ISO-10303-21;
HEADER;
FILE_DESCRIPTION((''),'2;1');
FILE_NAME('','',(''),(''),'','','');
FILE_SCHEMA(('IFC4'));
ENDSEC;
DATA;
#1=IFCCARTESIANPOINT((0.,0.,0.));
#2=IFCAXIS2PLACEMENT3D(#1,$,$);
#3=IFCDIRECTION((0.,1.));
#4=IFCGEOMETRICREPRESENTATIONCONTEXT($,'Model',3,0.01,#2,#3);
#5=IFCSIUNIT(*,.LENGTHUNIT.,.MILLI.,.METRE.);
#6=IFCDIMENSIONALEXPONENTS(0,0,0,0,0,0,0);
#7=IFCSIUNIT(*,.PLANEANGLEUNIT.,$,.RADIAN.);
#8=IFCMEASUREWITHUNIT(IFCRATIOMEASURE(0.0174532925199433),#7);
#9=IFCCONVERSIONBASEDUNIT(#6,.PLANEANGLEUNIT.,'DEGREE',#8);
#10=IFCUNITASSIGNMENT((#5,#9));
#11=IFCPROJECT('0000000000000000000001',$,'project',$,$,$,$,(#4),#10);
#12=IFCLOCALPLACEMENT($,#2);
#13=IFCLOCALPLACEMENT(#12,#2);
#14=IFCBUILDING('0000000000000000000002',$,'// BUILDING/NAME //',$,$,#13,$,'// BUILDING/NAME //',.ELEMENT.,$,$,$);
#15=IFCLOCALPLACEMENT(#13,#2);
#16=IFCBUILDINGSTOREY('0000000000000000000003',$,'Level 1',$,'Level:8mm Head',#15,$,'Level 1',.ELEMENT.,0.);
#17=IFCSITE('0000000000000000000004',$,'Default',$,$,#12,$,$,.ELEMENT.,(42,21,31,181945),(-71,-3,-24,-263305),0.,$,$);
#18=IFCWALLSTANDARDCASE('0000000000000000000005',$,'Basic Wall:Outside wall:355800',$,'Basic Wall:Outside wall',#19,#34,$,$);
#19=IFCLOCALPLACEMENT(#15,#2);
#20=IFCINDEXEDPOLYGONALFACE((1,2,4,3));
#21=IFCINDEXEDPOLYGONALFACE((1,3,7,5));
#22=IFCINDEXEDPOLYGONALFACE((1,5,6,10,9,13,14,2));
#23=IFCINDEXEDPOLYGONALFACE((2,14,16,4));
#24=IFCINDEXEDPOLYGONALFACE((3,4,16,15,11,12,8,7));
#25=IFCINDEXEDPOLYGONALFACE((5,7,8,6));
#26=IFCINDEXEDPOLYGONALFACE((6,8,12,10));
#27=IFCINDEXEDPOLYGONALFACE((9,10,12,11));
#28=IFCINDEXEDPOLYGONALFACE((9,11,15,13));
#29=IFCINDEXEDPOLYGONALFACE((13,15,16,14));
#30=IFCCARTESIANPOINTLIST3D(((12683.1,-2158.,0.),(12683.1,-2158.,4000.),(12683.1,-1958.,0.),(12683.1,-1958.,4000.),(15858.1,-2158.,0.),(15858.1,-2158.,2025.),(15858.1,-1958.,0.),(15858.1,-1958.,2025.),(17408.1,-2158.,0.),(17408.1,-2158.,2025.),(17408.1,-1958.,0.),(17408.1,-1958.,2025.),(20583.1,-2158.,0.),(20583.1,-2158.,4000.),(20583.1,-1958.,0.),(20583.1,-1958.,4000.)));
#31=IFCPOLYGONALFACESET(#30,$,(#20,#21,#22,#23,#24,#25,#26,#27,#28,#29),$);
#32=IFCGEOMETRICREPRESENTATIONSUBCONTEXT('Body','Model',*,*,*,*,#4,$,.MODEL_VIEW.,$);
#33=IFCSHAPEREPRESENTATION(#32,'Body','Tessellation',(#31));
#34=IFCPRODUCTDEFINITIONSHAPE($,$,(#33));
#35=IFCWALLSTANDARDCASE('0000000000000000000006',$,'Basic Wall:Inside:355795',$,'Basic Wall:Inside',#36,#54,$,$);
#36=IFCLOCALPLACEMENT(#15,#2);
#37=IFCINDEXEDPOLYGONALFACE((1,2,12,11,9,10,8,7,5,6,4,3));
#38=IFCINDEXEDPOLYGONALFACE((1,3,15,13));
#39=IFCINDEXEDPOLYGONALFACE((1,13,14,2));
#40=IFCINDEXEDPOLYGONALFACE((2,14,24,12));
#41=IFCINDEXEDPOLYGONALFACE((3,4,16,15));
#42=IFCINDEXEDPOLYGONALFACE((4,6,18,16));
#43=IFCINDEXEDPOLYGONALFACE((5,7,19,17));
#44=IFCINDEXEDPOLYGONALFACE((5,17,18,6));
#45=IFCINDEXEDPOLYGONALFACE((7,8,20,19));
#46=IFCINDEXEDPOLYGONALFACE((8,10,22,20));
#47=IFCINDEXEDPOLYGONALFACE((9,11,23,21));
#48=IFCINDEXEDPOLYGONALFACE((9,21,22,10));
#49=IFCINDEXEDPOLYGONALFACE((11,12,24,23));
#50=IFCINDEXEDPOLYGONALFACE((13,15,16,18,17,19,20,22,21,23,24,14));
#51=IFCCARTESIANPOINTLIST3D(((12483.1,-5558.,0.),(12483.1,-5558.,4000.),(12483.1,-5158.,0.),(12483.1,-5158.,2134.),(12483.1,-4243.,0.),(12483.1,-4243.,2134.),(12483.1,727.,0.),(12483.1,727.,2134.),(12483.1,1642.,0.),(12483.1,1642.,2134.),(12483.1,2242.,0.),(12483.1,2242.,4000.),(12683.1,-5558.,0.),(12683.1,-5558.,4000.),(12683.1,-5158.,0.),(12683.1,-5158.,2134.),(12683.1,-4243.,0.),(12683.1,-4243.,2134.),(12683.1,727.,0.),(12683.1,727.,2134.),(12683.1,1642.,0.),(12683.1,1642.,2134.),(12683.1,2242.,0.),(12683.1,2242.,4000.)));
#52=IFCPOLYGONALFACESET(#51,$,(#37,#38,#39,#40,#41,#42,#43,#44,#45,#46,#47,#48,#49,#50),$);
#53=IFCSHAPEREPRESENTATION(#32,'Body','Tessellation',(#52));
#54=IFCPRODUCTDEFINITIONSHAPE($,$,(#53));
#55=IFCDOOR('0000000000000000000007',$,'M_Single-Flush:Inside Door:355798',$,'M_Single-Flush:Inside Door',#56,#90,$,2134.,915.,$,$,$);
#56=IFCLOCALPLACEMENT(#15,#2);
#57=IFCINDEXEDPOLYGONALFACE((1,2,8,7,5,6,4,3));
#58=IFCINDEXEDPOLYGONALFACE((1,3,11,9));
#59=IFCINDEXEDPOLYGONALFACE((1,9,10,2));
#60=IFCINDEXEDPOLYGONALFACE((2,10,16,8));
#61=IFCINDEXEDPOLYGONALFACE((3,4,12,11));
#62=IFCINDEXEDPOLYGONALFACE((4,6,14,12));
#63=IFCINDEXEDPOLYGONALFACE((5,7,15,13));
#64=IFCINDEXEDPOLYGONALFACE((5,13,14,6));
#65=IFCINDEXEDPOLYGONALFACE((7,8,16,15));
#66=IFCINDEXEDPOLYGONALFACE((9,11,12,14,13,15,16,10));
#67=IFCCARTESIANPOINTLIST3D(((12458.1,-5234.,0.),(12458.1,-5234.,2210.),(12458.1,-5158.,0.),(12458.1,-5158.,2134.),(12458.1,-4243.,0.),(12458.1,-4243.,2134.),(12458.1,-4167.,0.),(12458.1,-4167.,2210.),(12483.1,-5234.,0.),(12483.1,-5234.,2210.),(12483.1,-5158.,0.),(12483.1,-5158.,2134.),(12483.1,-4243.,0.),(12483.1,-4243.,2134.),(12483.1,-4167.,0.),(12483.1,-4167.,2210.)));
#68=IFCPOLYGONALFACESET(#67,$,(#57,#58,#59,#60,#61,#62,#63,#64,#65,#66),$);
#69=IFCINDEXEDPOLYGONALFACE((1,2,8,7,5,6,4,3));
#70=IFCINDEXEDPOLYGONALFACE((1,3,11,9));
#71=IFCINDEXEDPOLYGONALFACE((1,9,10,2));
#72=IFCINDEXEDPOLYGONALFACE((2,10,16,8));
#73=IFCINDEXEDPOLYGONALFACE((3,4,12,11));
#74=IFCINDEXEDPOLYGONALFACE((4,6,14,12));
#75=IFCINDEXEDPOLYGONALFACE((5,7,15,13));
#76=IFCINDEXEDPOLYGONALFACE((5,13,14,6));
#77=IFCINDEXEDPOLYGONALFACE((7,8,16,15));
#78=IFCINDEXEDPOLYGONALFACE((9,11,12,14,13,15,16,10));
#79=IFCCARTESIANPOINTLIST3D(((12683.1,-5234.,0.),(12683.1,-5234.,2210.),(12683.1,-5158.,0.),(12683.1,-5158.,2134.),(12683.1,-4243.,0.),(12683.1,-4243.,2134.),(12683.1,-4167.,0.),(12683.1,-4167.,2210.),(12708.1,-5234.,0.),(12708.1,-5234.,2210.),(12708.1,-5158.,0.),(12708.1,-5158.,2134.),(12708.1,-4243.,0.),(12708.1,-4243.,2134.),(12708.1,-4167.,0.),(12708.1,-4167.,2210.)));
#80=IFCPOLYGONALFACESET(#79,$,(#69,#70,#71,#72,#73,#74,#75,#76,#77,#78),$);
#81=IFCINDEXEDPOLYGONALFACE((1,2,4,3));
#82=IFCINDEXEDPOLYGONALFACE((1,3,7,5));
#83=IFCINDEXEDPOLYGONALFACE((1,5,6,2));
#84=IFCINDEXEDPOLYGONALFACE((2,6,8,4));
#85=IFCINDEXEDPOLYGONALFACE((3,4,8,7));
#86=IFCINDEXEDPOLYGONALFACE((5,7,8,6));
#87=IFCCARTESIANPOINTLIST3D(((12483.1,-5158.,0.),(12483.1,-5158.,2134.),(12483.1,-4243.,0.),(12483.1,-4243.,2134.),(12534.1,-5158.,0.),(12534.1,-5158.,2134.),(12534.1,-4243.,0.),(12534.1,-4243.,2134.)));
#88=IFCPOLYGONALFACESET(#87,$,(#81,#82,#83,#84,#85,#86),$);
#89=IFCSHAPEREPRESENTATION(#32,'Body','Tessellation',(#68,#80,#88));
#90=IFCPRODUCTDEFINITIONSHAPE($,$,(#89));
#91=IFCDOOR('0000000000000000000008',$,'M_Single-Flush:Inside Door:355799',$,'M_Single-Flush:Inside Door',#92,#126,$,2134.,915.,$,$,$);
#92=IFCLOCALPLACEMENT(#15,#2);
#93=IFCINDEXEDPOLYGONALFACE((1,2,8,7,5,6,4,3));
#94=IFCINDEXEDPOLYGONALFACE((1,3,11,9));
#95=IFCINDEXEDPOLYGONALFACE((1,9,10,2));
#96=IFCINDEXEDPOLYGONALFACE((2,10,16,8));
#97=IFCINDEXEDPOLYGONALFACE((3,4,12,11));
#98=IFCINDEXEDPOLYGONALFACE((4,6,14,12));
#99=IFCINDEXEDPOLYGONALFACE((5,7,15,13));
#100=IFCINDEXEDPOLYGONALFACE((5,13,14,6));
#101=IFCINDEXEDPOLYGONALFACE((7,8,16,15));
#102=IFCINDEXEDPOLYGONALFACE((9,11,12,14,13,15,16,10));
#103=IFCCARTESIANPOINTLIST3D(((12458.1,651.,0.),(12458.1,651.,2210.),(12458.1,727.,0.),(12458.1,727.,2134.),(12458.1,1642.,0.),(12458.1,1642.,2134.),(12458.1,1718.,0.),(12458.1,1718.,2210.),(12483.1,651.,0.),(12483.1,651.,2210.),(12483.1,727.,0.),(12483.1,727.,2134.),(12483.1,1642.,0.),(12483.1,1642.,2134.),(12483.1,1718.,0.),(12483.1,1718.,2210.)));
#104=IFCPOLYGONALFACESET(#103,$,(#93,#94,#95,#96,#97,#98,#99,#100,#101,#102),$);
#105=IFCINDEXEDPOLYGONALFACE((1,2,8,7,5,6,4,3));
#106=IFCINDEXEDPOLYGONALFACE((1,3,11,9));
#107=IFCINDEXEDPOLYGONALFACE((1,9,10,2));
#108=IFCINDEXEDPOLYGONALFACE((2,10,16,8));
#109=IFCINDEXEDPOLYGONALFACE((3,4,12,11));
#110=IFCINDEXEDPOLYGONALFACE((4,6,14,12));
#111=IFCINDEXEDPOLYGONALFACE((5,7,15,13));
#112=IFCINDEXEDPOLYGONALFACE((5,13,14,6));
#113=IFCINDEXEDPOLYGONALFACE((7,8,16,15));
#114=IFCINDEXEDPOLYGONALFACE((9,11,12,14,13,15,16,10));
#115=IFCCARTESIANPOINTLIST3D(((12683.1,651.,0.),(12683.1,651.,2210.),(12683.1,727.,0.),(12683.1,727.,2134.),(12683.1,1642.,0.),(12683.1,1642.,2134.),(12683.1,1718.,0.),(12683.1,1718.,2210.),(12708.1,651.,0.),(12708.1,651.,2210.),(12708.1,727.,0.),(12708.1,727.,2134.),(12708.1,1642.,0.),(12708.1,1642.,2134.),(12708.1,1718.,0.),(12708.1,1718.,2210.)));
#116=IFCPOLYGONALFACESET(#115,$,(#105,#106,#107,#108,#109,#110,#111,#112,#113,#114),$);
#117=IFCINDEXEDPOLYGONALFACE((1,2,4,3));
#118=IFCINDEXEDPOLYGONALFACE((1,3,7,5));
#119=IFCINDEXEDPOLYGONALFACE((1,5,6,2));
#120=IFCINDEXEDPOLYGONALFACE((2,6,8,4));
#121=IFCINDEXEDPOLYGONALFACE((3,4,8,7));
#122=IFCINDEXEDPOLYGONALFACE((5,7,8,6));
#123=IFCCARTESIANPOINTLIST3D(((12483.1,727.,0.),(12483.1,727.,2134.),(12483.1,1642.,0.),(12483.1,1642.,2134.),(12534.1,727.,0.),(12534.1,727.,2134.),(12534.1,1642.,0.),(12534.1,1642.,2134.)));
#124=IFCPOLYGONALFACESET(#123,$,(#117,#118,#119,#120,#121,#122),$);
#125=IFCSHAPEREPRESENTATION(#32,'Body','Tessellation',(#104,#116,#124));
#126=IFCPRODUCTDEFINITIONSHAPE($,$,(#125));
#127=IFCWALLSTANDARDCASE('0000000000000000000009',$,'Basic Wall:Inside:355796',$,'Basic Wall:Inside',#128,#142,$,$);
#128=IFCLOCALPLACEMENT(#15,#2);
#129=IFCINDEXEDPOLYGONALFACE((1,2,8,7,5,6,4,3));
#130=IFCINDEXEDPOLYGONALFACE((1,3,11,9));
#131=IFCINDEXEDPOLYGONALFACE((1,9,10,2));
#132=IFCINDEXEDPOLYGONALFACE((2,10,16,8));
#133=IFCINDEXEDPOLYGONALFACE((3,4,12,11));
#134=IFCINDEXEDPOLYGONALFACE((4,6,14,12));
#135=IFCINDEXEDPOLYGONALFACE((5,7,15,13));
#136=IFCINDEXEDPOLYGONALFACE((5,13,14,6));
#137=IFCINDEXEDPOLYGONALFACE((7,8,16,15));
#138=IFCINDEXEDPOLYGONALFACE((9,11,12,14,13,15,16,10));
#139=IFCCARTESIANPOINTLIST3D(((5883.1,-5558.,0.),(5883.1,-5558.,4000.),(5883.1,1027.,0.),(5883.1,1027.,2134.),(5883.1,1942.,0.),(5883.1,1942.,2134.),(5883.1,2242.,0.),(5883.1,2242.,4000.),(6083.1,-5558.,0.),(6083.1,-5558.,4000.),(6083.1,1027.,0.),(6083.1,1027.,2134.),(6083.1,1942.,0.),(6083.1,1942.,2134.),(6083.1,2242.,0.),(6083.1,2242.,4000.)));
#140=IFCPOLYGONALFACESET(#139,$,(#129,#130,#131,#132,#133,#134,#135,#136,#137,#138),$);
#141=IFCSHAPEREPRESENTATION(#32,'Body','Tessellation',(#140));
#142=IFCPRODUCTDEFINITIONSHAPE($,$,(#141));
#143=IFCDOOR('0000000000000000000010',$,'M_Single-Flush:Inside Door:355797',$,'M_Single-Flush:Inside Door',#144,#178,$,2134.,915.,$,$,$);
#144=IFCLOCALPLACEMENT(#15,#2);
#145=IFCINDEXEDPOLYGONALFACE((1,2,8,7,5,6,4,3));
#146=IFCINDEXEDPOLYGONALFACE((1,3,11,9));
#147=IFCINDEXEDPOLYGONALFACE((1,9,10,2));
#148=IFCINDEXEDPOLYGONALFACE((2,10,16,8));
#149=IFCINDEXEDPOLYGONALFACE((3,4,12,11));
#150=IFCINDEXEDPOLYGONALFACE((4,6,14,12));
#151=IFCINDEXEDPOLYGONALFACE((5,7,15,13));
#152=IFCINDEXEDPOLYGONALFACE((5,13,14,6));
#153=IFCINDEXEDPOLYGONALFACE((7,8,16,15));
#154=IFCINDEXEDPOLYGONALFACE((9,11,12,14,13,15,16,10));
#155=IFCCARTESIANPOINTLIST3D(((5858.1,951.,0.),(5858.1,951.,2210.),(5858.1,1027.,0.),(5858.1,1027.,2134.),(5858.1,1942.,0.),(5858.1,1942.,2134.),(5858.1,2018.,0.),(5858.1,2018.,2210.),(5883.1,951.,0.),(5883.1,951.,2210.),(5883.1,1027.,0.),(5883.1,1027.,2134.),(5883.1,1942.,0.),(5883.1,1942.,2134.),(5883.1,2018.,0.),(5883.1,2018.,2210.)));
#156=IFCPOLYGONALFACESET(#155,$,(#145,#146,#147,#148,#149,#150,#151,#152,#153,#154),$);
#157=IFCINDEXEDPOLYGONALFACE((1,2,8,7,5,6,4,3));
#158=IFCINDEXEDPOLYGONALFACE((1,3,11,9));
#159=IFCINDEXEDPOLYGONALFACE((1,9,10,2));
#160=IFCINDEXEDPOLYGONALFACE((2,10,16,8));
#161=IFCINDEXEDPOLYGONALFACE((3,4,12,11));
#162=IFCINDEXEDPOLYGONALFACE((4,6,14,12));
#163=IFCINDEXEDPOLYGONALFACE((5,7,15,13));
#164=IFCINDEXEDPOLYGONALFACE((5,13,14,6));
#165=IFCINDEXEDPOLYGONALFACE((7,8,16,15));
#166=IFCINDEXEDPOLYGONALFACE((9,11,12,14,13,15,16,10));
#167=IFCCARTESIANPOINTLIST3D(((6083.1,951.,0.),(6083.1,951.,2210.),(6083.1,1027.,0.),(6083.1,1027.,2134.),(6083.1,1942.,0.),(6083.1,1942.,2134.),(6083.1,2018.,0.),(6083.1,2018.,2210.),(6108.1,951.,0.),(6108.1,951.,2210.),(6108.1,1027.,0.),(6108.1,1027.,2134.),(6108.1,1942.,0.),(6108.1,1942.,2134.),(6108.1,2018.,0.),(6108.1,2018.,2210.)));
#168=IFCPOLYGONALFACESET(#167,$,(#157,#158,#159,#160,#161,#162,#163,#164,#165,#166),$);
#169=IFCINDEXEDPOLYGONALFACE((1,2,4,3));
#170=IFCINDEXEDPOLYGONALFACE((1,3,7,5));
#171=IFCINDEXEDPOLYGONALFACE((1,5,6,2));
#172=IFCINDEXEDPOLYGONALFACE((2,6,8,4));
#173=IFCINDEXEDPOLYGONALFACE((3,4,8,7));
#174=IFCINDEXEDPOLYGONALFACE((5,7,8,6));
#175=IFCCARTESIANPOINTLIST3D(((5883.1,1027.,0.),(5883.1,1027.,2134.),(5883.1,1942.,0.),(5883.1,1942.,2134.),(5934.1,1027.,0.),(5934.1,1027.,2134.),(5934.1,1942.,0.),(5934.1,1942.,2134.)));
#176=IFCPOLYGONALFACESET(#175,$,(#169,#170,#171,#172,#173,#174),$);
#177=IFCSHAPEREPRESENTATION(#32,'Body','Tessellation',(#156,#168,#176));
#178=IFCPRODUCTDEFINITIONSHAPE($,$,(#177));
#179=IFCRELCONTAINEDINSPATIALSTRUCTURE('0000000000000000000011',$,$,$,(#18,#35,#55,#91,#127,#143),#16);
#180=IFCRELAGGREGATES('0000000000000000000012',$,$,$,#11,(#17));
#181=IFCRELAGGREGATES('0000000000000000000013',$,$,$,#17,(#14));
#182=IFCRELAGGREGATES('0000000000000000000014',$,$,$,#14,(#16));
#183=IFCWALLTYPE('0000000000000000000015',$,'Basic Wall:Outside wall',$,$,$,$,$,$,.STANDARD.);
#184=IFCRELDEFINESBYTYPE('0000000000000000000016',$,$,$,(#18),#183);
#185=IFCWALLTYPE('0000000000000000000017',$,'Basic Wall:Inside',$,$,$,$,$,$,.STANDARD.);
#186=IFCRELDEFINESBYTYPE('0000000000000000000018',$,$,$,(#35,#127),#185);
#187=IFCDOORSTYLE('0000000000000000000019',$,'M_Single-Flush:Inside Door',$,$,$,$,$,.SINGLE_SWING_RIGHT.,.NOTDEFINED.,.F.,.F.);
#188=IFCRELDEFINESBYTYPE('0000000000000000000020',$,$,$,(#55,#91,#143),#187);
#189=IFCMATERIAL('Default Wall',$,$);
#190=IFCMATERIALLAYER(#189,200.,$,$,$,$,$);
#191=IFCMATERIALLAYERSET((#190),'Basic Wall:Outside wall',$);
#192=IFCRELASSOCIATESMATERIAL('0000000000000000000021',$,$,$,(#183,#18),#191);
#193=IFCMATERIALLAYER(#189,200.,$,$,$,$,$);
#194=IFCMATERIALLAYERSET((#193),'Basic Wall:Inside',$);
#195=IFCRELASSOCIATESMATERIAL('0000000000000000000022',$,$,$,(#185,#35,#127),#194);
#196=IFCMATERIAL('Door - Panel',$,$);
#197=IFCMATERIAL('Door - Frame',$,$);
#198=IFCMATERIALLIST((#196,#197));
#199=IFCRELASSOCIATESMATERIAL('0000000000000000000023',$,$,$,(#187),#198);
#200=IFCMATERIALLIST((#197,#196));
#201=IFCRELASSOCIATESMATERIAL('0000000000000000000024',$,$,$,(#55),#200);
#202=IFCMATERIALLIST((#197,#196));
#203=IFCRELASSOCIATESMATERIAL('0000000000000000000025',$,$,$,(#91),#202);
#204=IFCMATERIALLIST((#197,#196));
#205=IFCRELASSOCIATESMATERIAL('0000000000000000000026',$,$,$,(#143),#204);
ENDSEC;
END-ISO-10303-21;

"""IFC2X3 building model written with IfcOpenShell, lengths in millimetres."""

from ifc_helpers import new_model, entity, si_unit, converted_unit, direction, frame, frame_2d, origin, place, context, subcontext, project, spatial, polyline, rectangle, outline, extrude, source, transform, mapped, material, material_list, layer, layer_set, layer_usage, type_object, type_shapes, element, fill, save


model = new_model("IFC2X3")

# Units and contexts
model_context = context("Model", 3, precision=0.01, world=origin(), true_north=direction((0.0, 1.0)))
body_context = subcontext(model_context, "Body", "Model", "MODEL_VIEW")
ifc_project = project(units=[si_unit("LENGTHUNIT", "METRE", prefix="MILLI"), converted_unit("PLANEANGLEUNIT", "DEGREE", entity("IfcRatioMeasure", 0.0174532925199433), si_unit("PLANEANGLEUNIT", "RADIAN"), dimensions=[0, 0, 0, 0, 0, 0, 0])], contexts=[model_context])

# Site, building, storey
site_placement = place(None, origin())
site = spatial("IfcSite", under=ifc_project, at=site_placement, Name="Default", CompositionType="ELEMENT", RefLatitude=(42, 21, 31, 181945), RefLongitude=(-71, -3, -24, -263305), RefElevation=0.0)
building_placement = place(site_placement, origin())
building = spatial("IfcBuilding", under=site, at=building_placement, Name="// BUILDING/NAME //", LongName="// BUILDING/NAME //", CompositionType="ELEMENT")
storey_placement = place(building_placement, origin())
storey = spatial("IfcBuildingStorey", under=building, at=storey_placement, Name="Level 1", ObjectType="Level:8mm Head", LongName="Level 1", CompositionType="ELEMENT", Elevation=0.0)

# Wall, opening
ifc_material_1 = material(Name="Default Wall")
ifc_layer_1 = layer(ifc_material_1, 200.0)
ifc_layer_set_1 = layer_set([ifc_layer_1], Name="Basic Wall:Outside wall")
ifc_layer_usage_1 = layer_usage(ifc_layer_set_1, "AXIS2", "NEGATIVE", 100.0)
wall_type_1 = type_object("IfcWallType", Name="Basic Wall:Outside wall", PredefinedType="STANDARD", material=ifc_layer_set_1)
wall_1_placement = place(storey_placement, frame((12683.1, -2058.0, 0.0)))
wall_1 = element("IfcWallStandardCase", 1, at=wall_1_placement, inside=storey, type_object=wall_type_1, material=ifc_layer_usage_1, Name="Basic Wall:Outside wall:355800", ObjectType="Basic Wall:Outside wall", context=body_context, shape_type="SweptSolid", body=[
    extrude(rectangle(XDim=7900.0, YDim=200.0, at=frame_2d((3950.0, 0.0), x_axis=(-1.0, 0.0))), origin(), (0.0, 0.0, 1.0), 4000.0),
])
opening_1_placement = place(wall_1_placement, frame((4725.0, 100.0, 0.0)))
element("IfcOpeningElement", 2, at=opening_1_placement, cuts=wall_1, ObjectType="Opening", context=body_context, shape_type="SweptSolid", body=[
    extrude(rectangle(XDim=2025.0, YDim=1550.0, at=frame_2d((1012.5, 775.0), x_axis=(1.0, 0.0))), frame((0.0, 0.0, 0.0), z_axis=(0.0, -1.0, 0.0), x_axis=(0.0, 0.0, 1.0)), (0.0, 0.0, 1.0), 200.0),
])

# Wall, openings, doors
ifc_layer_2 = layer(ifc_material_1, 200.0)
ifc_layer_set_2 = layer_set([ifc_layer_2], Name="Basic Wall:Inside")
ifc_layer_usage_2 = layer_usage(ifc_layer_set_2, "AXIS2", "NEGATIVE", 100.0)
wall_type_2 = type_object("IfcWallType", Name="Basic Wall:Inside", PredefinedType="STANDARD", material=ifc_layer_set_2)
wall_2_placement = place(storey_placement, frame((12583.1, -5558.0, 0.0), z_axis=(0.0, 0.0, 1.0), x_axis=(0.0, 1.0, 0.0)))
wall_2 = element("IfcWallStandardCase", 3, at=wall_2_placement, inside=storey, type_object=wall_type_2, material=ifc_layer_usage_2, Name="Basic Wall:Inside:355795", ObjectType="Basic Wall:Inside", context=body_context, shape_type="SweptSolid", body=[
    extrude(rectangle(XDim=7800.0, YDim=200.0, at=frame_2d((3900.0, 0.0), x_axis=(-1.0, 0.0))), origin(), (0.0, 0.0, 1.0), 4000.0),
])
opening_2_placement = place(wall_2_placement, frame((400.0, -100.0, 0.0)))
opening_2 = element("IfcOpeningElement", 4, at=opening_2_placement, cuts=wall_2, ObjectType="Opening", context=body_context, shape_type="SweptSolid", body=[
    extrude(rectangle(XDim=915.0, YDim=2134.0, at=frame_2d((1067.0, 457.5), x_axis=(0.0, 1.0))), frame((0.0, 0.0, 0.0), z_axis=(0.0, 1.0, 0.0), x_axis=(0.0, 0.0, 1.0)), (0.0, 0.0, 1.0), 200.0),
])
opening_3_placement = place(wall_2_placement, frame((6285.0, -100.0, 0.0)))
opening_3 = element("IfcOpeningElement", 5, at=opening_3_placement, cuts=wall_2, ObjectType="Opening", context=body_context, shape_type="SweptSolid", body=[
    extrude(rectangle(XDim=915.0, YDim=2134.0, at=frame_2d((1067.0, 457.5), x_axis=(0.0, 1.0))), frame((0.0, 0.0, 0.0), z_axis=(0.0, 1.0, 0.0), x_axis=(0.0, 0.0, 1.0)), (0.0, 0.0, 1.0), 200.0),
])
ifc_material_2 = material(Name="Door - Frame")
ifc_material_3 = material(Name="Door - Panel")
ifc_material_list_1 = material_list([ifc_material_2, ifc_material_3])
ifc_material_list_2 = material_list([ifc_material_3, ifc_material_2])
door_style = type_object("IfcDoorStyle", Name="M_Single-Flush:Inside Door", ConstructionType="NOTDEFINED", OperationType="SINGLE_SWING_RIGHT", ParameterTakesPrecedence=False, Sizeable=False, material=ifc_material_list_2)
shared_shape = source(origin(), body_context, "Body", "SweptSolid", [
    extrude(outline(polyline([(-533.5, -1124.0), (533.5, -1124.0), (533.5, 1086.0), (457.5, 1086.0), (457.5, -1048.0), (-457.5, -1048.0), (-457.5, 1086.0), (-533.5, 1086.0), (-533.5, -1124.0)])), frame((457.5, 200.0, 1086.0), z_axis=(0.0, 1.0, 0.0), x_axis=(1.0, 0.0, 0.0)), (0.0, 0.0, 1.0), 25.0),
    extrude(outline(polyline([(-1124.0, -533.5), (1086.0, -533.5), (1086.0, -457.5), (-1048.0, -457.5), (-1048.0, 457.5), (1086.0, 457.5), (1086.0, 533.5), (-1124.0, 533.5), (-1124.0, -533.5)])), frame((457.5, -25.0, 1086.0), z_axis=(0.0, 1.0, 0.0), x_axis=(0.0, 0.0, -1.0)), (0.0, 0.0, 1.0), 25.0),
    extrude(rectangle(XDim=51.0, YDim=915.0, at=frame_2d((0.0, 0.0), x_axis=(1.0, 0.0))), frame((457.5, 174.5, 0.0), z_axis=(0.0, 0.0, 1.0), x_axis=(0.0, 1.0, 0.0)), (0.0, 0.0, 1.0), 2134.0),
])
type_shapes(door_style, [shared_shape])
door_1_placement = place(opening_2_placement, origin())
door_1 = element("IfcDoor", 6, at=door_1_placement, inside=storey, type_object=door_style, material=ifc_material_list_1, Name="M_Single-Flush:Inside Door:355798", ObjectType="M_Single-Flush:Inside Door", OverallHeight=2134.0, OverallWidth=915.0, context=body_context, shape_type="MappedRepresentation", body=[
    mapped(shared_shape, transform((0.0, 0.0, 0.0), scale=1.0)),
])
fill(opening_2, door_1)
ifc_material_list_3 = material_list([ifc_material_2, ifc_material_3])
door_2_placement = place(opening_3_placement, origin())
door_2 = element("IfcDoor", 7, at=door_2_placement, inside=storey, type_object=door_style, material=ifc_material_list_3, Name="M_Single-Flush:Inside Door:355799", ObjectType="M_Single-Flush:Inside Door", OverallHeight=2134.0, OverallWidth=915.0, context=body_context, shape_type="MappedRepresentation", body=[
    mapped(shared_shape, transform((0.0, 0.0, 0.0), scale=1.0)),
])
fill(opening_3, door_2)

# Wall, opening, door
ifc_layer_usage_3 = layer_usage(ifc_layer_set_2, "AXIS2", "NEGATIVE", 100.0)
wall_3_placement = place(storey_placement, frame((5983.1, -5558.0, 0.0), z_axis=(0.0, 0.0, 1.0), x_axis=(0.0, 1.0, 0.0)))
wall_3 = element("IfcWallStandardCase", 8, at=wall_3_placement, inside=storey, type_object=wall_type_2, material=ifc_layer_usage_3, Name="Basic Wall:Inside:355796", ObjectType="Basic Wall:Inside", context=body_context, shape_type="SweptSolid", body=[
    extrude(rectangle(XDim=7800.0, YDim=200.0, at=frame_2d((3900.0, 0.0), x_axis=(-1.0, 0.0))), origin(), (0.0, 0.0, 1.0), 4000.0),
])
opening_4_placement = place(wall_3_placement, frame((6585.0, -100.0, 0.0)))
opening_4 = element("IfcOpeningElement", 9, at=opening_4_placement, cuts=wall_3, ObjectType="Opening", context=body_context, shape_type="SweptSolid", body=[
    extrude(rectangle(XDim=915.0, YDim=2134.0, at=frame_2d((1067.0, 457.5), x_axis=(0.0, 1.0))), frame((0.0, 0.0, 0.0), z_axis=(0.0, 1.0, 0.0), x_axis=(0.0, 0.0, 1.0)), (0.0, 0.0, 1.0), 200.0),
])
ifc_material_list_4 = material_list([ifc_material_2, ifc_material_3])
door_3_placement = place(opening_4_placement, origin())
door_3 = element("IfcDoor", 10, at=door_3_placement, inside=storey, type_object=door_style, material=ifc_material_list_4, Name="M_Single-Flush:Inside Door:355797", ObjectType="M_Single-Flush:Inside Door", OverallHeight=2134.0, OverallWidth=915.0, context=body_context, shape_type="MappedRepresentation", body=[
    mapped(shared_shape, transform((0.0, 0.0, 0.0), scale=1.0)),
])
fill(opening_4, door_3)

save(model, "model.ifc")
